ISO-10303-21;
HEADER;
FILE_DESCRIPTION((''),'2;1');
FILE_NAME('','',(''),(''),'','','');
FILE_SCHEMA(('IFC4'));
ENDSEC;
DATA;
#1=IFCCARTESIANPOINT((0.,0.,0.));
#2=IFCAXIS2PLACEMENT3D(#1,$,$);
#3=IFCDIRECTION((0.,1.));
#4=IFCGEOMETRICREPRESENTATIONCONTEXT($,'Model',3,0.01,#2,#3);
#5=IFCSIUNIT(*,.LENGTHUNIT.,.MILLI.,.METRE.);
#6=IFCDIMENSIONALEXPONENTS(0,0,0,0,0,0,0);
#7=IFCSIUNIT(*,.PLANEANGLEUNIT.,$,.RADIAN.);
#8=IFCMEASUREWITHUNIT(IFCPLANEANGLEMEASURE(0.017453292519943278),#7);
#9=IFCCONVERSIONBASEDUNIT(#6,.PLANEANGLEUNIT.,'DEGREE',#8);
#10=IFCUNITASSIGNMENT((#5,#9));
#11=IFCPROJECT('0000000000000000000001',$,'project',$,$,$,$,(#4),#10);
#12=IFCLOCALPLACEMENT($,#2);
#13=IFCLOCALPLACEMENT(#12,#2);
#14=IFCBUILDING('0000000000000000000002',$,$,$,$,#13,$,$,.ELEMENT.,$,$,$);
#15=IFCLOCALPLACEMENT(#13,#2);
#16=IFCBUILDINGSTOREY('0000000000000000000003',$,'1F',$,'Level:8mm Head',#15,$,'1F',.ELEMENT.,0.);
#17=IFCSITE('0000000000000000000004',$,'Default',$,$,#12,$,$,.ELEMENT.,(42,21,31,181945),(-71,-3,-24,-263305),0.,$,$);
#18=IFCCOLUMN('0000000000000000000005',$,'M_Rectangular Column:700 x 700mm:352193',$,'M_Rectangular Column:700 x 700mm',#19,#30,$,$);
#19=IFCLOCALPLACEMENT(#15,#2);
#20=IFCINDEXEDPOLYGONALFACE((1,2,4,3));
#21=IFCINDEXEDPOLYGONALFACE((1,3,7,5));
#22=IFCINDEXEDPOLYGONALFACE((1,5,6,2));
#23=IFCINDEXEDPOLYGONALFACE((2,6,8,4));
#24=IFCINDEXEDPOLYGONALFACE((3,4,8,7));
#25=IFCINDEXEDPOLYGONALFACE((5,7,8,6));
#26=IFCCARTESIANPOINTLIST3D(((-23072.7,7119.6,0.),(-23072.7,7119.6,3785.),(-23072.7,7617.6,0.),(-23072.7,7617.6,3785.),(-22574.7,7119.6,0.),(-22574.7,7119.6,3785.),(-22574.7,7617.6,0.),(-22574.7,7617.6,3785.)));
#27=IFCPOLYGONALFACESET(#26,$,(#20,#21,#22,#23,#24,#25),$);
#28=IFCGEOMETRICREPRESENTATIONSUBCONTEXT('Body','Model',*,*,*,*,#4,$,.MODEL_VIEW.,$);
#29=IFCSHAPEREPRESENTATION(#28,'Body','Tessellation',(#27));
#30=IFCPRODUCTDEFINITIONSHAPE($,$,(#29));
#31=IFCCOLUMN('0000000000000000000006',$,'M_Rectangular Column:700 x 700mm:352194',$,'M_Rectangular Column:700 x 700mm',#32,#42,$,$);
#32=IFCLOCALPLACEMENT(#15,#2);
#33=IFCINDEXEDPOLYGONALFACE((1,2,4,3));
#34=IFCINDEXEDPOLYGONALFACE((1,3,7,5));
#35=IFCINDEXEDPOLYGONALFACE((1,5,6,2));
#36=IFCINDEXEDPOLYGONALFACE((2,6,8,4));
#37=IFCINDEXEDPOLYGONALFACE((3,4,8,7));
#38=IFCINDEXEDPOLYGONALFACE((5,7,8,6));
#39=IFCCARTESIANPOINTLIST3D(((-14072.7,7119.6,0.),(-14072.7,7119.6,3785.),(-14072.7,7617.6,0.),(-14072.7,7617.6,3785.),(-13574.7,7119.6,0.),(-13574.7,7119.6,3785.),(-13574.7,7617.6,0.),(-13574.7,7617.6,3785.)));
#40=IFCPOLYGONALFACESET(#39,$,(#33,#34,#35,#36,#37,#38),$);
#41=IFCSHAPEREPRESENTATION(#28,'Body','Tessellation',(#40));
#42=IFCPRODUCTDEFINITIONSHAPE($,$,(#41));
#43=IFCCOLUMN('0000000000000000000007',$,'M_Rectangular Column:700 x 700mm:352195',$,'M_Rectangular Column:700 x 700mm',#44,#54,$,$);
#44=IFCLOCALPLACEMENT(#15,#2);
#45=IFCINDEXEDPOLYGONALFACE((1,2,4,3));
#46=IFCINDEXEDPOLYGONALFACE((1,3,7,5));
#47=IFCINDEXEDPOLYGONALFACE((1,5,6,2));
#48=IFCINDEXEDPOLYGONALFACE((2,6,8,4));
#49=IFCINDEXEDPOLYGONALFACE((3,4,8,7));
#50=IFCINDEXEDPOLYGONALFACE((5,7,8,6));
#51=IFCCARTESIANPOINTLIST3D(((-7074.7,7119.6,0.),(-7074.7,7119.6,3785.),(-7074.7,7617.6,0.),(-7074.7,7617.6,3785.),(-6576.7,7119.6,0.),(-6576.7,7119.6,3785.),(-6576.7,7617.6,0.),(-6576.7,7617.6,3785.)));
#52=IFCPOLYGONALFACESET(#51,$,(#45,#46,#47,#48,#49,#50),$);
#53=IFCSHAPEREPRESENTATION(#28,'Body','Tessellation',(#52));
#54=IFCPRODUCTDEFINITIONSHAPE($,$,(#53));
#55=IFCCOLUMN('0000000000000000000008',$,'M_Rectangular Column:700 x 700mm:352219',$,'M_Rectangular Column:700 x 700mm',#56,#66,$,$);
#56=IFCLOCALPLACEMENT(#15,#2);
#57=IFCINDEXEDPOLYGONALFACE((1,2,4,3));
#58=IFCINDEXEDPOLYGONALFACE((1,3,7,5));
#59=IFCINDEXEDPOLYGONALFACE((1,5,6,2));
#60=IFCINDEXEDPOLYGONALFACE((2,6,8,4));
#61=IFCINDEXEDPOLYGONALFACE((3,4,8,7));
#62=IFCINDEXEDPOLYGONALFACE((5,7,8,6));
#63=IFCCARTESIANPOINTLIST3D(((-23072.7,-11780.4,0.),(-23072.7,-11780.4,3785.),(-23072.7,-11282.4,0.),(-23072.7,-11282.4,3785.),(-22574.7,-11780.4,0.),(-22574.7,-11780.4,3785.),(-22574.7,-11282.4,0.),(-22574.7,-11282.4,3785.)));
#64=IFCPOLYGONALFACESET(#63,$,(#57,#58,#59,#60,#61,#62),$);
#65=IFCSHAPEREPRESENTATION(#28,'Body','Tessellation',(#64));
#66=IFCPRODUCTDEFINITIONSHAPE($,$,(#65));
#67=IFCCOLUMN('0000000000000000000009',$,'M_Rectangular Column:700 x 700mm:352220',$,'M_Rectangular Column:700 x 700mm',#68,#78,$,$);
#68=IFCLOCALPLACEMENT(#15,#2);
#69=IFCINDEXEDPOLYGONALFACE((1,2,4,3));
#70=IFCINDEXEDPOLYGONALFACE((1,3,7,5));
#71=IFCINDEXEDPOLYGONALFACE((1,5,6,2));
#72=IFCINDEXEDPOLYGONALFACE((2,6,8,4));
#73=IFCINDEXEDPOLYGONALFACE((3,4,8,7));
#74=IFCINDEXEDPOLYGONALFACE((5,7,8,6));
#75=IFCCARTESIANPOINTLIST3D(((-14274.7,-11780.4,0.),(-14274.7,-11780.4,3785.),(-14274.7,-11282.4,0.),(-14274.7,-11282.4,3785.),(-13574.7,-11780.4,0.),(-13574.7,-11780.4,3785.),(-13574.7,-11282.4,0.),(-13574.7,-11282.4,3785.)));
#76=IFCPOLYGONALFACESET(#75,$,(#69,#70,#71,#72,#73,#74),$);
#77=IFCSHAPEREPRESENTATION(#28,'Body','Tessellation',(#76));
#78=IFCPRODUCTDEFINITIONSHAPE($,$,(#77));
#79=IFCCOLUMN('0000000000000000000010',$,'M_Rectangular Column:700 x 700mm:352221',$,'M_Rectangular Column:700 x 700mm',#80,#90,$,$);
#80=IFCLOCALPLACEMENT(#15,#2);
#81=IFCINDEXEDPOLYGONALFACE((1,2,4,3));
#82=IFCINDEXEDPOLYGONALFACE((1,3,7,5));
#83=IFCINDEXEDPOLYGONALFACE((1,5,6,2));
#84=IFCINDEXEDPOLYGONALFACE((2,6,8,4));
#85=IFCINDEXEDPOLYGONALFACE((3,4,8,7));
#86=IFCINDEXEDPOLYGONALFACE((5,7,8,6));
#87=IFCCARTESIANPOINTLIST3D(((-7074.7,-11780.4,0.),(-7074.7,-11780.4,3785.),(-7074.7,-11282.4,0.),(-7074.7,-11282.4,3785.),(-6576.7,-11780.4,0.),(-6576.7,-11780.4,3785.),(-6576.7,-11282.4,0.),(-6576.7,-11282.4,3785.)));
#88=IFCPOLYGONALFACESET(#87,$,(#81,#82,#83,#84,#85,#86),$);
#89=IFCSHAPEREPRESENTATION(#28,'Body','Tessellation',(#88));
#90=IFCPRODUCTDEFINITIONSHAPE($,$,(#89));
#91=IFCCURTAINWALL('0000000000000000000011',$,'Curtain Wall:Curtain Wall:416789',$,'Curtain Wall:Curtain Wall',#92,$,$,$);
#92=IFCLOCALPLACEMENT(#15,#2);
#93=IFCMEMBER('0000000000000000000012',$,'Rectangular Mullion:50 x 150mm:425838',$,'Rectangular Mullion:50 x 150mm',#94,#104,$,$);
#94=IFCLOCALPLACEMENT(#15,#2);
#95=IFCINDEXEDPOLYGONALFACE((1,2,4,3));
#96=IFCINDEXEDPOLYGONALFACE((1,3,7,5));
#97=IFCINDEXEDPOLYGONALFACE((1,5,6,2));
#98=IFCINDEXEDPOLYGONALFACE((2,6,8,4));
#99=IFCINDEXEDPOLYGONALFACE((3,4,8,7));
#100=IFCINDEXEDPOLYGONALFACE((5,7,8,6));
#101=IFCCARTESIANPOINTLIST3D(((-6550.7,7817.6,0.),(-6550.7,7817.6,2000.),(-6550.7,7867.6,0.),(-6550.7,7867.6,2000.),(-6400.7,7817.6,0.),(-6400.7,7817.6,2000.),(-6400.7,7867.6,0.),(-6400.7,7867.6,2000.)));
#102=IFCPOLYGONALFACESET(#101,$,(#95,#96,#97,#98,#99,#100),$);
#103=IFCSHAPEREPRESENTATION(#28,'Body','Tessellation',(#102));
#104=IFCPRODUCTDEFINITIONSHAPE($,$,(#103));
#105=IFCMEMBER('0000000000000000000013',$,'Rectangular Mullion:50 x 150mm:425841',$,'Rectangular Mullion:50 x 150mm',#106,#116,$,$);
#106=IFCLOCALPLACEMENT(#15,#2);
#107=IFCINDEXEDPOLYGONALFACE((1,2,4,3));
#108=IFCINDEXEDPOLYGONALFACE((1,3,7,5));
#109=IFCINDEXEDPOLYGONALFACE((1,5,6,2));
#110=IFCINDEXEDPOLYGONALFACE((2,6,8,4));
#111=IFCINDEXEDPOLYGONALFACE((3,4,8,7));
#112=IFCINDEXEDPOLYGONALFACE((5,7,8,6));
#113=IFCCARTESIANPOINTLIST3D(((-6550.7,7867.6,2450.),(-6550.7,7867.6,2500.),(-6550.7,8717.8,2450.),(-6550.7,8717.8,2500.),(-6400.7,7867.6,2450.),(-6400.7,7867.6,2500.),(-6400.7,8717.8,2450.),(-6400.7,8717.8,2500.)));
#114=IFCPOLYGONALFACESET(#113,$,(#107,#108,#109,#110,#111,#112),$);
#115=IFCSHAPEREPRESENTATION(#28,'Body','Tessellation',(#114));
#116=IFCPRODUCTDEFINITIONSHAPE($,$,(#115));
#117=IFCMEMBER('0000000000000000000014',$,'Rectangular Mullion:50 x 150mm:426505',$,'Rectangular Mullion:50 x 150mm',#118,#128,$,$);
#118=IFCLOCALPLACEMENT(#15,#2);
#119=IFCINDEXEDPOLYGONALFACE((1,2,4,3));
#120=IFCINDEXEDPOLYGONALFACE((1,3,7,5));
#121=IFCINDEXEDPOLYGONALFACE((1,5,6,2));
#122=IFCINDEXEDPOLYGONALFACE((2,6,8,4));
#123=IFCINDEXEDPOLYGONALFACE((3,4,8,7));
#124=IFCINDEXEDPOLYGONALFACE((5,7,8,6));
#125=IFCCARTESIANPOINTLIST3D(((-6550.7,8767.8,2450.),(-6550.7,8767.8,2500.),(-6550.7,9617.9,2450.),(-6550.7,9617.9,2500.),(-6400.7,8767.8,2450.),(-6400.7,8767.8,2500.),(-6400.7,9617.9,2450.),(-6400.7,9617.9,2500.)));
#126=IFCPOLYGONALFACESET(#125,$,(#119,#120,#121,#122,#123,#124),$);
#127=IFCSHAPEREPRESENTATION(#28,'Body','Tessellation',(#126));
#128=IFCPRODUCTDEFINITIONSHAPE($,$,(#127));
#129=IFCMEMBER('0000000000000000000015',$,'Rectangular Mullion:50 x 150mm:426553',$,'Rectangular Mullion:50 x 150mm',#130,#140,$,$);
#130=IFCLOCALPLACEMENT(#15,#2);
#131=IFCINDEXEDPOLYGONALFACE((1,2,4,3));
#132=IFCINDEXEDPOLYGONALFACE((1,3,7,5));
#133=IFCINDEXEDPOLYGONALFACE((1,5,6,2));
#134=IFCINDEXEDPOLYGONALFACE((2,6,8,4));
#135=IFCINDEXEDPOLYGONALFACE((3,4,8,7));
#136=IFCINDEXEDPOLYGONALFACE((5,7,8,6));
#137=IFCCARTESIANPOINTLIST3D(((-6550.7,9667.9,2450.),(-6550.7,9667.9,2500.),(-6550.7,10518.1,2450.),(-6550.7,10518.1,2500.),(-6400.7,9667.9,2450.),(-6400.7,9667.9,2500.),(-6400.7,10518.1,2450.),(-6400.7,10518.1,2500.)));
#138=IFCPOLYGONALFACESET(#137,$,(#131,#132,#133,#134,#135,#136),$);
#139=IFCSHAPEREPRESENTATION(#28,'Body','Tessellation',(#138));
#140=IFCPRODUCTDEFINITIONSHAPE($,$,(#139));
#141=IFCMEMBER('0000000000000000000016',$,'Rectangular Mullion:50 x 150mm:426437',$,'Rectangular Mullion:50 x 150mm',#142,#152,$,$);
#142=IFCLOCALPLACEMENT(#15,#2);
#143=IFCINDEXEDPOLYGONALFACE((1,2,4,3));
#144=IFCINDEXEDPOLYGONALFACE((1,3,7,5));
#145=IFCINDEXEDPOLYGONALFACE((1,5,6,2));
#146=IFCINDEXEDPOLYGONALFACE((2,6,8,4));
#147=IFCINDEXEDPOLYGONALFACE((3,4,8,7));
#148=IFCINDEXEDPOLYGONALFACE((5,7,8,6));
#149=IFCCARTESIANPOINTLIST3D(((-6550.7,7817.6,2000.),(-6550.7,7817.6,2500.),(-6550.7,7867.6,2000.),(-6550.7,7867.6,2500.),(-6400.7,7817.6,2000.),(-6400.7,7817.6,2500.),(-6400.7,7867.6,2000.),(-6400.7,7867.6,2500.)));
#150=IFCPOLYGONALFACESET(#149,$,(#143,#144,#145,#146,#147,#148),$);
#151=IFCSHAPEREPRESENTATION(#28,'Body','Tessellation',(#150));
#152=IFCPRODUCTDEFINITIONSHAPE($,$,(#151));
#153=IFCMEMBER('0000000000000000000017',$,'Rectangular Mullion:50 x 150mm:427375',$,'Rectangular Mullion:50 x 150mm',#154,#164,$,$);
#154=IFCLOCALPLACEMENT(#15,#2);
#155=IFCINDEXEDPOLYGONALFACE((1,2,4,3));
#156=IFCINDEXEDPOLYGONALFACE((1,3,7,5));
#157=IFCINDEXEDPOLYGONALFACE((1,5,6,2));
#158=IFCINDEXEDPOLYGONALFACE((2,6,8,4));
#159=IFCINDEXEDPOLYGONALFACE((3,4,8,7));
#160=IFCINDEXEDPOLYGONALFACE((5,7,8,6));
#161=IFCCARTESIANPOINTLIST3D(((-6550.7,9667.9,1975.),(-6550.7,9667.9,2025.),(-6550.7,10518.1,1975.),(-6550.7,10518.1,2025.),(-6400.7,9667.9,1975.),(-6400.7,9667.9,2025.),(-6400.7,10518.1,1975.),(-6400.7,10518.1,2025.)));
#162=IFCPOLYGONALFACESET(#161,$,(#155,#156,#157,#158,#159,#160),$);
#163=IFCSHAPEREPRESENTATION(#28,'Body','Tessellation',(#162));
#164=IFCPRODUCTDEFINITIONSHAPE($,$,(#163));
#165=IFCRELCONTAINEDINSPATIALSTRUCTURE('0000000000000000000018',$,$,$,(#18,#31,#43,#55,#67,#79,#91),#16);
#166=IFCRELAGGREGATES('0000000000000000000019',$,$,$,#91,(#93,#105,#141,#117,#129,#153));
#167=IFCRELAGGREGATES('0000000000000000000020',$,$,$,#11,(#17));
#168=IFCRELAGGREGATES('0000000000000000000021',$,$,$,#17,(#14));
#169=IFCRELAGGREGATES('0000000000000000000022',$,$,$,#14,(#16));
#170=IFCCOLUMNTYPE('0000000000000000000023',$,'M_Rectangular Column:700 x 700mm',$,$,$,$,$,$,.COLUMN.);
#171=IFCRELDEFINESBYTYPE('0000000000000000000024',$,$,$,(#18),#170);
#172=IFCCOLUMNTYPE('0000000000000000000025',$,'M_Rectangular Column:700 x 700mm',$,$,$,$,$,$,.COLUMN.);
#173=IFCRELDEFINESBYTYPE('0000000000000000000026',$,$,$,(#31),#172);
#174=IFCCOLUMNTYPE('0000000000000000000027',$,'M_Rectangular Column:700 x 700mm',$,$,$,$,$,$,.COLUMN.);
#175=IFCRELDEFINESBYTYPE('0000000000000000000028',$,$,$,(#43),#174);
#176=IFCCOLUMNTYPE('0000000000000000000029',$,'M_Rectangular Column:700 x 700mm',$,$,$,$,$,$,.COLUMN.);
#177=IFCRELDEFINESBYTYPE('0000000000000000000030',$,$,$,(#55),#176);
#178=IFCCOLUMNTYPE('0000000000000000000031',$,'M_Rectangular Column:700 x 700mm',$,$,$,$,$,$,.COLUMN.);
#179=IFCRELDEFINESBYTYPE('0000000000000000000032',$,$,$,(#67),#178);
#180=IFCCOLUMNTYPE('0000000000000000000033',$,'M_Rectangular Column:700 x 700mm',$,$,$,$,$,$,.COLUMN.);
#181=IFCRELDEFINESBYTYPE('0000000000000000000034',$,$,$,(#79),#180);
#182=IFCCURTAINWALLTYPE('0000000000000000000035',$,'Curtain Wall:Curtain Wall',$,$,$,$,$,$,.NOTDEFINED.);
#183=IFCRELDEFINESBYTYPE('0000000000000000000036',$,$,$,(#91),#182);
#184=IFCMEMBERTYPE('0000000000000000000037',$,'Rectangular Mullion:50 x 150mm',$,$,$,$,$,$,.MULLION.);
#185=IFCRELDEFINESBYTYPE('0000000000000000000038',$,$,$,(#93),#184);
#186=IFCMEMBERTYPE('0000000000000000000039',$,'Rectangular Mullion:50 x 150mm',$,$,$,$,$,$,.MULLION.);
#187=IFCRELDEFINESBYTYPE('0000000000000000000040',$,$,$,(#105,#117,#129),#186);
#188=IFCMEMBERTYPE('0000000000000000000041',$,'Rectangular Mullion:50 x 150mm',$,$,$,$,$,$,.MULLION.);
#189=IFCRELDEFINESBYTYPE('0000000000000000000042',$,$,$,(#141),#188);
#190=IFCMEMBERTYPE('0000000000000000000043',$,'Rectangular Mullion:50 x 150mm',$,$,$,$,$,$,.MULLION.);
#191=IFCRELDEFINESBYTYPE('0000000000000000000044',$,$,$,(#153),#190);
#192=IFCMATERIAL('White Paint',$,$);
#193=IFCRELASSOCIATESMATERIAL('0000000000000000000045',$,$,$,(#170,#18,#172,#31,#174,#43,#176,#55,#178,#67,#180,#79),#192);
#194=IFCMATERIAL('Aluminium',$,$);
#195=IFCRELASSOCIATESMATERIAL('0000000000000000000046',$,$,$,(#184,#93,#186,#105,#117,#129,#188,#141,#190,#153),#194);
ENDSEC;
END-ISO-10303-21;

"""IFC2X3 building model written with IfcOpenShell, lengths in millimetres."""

from ifc_helpers import new_model, entity, si_unit, converted_unit, direction, frame, frame_2d, origin, origin_2d_with_axis, place, context, subcontext, project, spatial, rectangle, extrude, source, transform, mapped, material, type_object, type_shapes, element, aggregate, save


model = new_model("IFC2X3")

# Units and contexts
model_context = context("Model", 3, precision=0.01, world=origin(), true_north=direction((0.0, 1.0)))
body_context = subcontext(model_context, "Body", "Model", "MODEL_VIEW")
ifc_project = project(units=[si_unit("LENGTHUNIT", "METRE", prefix="MILLI"), converted_unit("PLANEANGLEUNIT", "DEGREE", entity("IfcPlaneAngleMeasure", 0.017453292519943278), si_unit("PLANEANGLEUNIT", "RADIAN"), dimensions=[0, 0, 0, 0, 0, 0, 0])], contexts=[model_context])

# Site, building, storey
site_placement = place(None, origin())
site = spatial("IfcSite", under=ifc_project, at=site_placement, Name="Default", CompositionType="ELEMENT", RefLatitude=(42, 21, 31, 181945), RefLongitude=(-71, -3, -24, -263305), RefElevation=0.0)
building_placement = place(site_placement, origin())
building = spatial("IfcBuilding", under=site, at=building_placement, CompositionType="ELEMENT")
storey_placement = place(building_placement, origin())
storey = spatial("IfcBuildingStorey", under=building, at=storey_placement, Name="1F", ObjectType="Level:8mm Head", LongName="1F", CompositionType="ELEMENT", Elevation=0.0)

# Columns
ifc_material_1 = material(Name="White Paint")
column_type_1 = type_object("IfcColumnType", Name="M_Rectangular Column:700 x 700mm", PredefinedType="COLUMN", material=ifc_material_1)
shared_shape_1 = source(origin(), body_context, "Body", "SweptSolid", [
    extrude(rectangle(XDim=498.0, YDim=498.0, at=frame_2d((0.0, 0.0), x_axis=(1.0, 0.0))), frame((-22823.7, 7368.6, 0.0), z_axis=(0.0, 0.0, 1.0), x_axis=(0.0, -1.0, 0.0)), (0.0, 0.0, 1.0), 3785.0),
])
type_shapes(column_type_1, [shared_shape_1])
column_1_placement = place(storey_placement, origin())
element("IfcColumn", 1, at=column_1_placement, inside=storey, type_object=column_type_1, material=ifc_material_1, Name="M_Rectangular Column:700 x 700mm:352193", ObjectType="M_Rectangular Column:700 x 700mm", context=body_context, shape_type="MappedRepresentation", body=[
    mapped(shared_shape_1, transform((0.0, 0.0, 0.0), scale=1.0)),
])
column_type_2 = type_object("IfcColumnType", Name="M_Rectangular Column:700 x 700mm", PredefinedType="COLUMN", material=ifc_material_1)
shared_shape_2 = source(origin(), body_context, "Body", "SweptSolid", [
    extrude(rectangle(XDim=498.0, YDim=498.0, at=frame_2d((0.0, 0.0), x_axis=(1.0, 0.0))), frame((-13823.7, 7368.6, 0.0), z_axis=(0.0, 0.0, 1.0), x_axis=(-1.0, 0.0, 0.0)), (0.0, 0.0, 1.0), 3785.0),
])
type_shapes(column_type_2, [shared_shape_2])
column_2_placement = place(storey_placement, origin())
element("IfcColumn", 2, at=column_2_placement, inside=storey, type_object=column_type_2, material=ifc_material_1, Name="M_Rectangular Column:700 x 700mm:352194", ObjectType="M_Rectangular Column:700 x 700mm", context=body_context, shape_type="MappedRepresentation", body=[
    mapped(shared_shape_2, transform((0.0, 0.0, 0.0), scale=1.0)),
])
column_type_3 = type_object("IfcColumnType", Name="M_Rectangular Column:700 x 700mm", PredefinedType="COLUMN", material=ifc_material_1)
shared_shape_3 = source(origin(), body_context, "Body", "SweptSolid", [
    extrude(rectangle(XDim=498.0, YDim=498.0, at=frame_2d((0.0, 0.0), x_axis=(1.0, 0.0))), frame((-6825.7, 7368.6, 0.0)), (0.0, 0.0, 1.0), 3785.0),
])
type_shapes(column_type_3, [shared_shape_3])
column_3_placement = place(storey_placement, origin())
element("IfcColumn", 3, at=column_3_placement, inside=storey, type_object=column_type_3, material=ifc_material_1, Name="M_Rectangular Column:700 x 700mm:352195", ObjectType="M_Rectangular Column:700 x 700mm", context=body_context, shape_type="MappedRepresentation", body=[
    mapped(shared_shape_3, transform((0.0, 0.0, 0.0), scale=1.0)),
])
column_type_4 = type_object("IfcColumnType", Name="M_Rectangular Column:700 x 700mm", PredefinedType="COLUMN", material=ifc_material_1)
shared_shape_4 = source(origin(), body_context, "Body", "SweptSolid", [
    extrude(rectangle(XDim=498.0, YDim=498.0, at=frame_2d((0.0, 0.0), x_axis=(1.0, 0.0))), frame((-22823.7, -11531.4, 0.0), z_axis=(0.0, 0.0, 1.0), x_axis=(0.0, -1.0, 0.0)), (0.0, 0.0, 1.0), 3785.0),
])
type_shapes(column_type_4, [shared_shape_4])
column_4_placement = place(storey_placement, origin())
element("IfcColumn", 4, at=column_4_placement, inside=storey, type_object=column_type_4, material=ifc_material_1, Name="M_Rectangular Column:700 x 700mm:352219", ObjectType="M_Rectangular Column:700 x 700mm", context=body_context, shape_type="MappedRepresentation", body=[
    mapped(shared_shape_4, transform((0.0, 0.0, 0.0), scale=1.0)),
])
column_type_5 = type_object("IfcColumnType", Name="M_Rectangular Column:700 x 700mm", PredefinedType="COLUMN", material=ifc_material_1)
shared_shape_5 = source(origin(), body_context, "Body", "SweptSolid", [
    extrude(rectangle(XDim=3785.0, YDim=498.0, at=frame_2d((0.0, 0.0), x_axis=(1.0, 0.0))), frame((-14274.7, -11531.4, 1892.5), z_axis=(1.0, 0.0, 0.0), x_axis=(0.0, 0.0, 1.0)), (0.0, 0.0, 1.0), 700.0),
])
type_shapes(column_type_5, [shared_shape_5])
column_5_placement = place(storey_placement, origin())
element("IfcColumn", 5, at=column_5_placement, inside=storey, type_object=column_type_5, material=ifc_material_1, Name="M_Rectangular Column:700 x 700mm:352220", ObjectType="M_Rectangular Column:700 x 700mm", context=body_context, shape_type="MappedRepresentation", body=[
    mapped(shared_shape_5, transform((0.0, 0.0, 0.0), scale=1.0)),
])
column_type_6 = type_object("IfcColumnType", Name="M_Rectangular Column:700 x 700mm", PredefinedType="COLUMN", material=ifc_material_1)
shared_shape_6 = source(origin(), body_context, "Body", "SweptSolid", [
    extrude(rectangle(XDim=498.0, YDim=498.0, at=frame_2d((0.0, 0.0), x_axis=(1.0, 0.0))), frame((-6825.7, -11531.4, 0.0)), (0.0, 0.0, 1.0), 3785.0),
])
type_shapes(column_type_6, [shared_shape_6])
column_6_placement = place(storey_placement, origin())
element("IfcColumn", 6, at=column_6_placement, inside=storey, type_object=column_type_6, material=ifc_material_1, Name="M_Rectangular Column:700 x 700mm:352221", ObjectType="M_Rectangular Column:700 x 700mm", context=body_context, shape_type="MappedRepresentation", body=[
    mapped(shared_shape_6, transform((0.0, 0.0, 0.0), scale=1.0)),
])

# Curtain wall, members
curtain_wall_type = type_object("IfcCurtainWallType", Name="Curtain Wall:Curtain Wall", PredefinedType="NOTDEFINED")
curtain_wall_placement = place(storey_placement, origin())
curtain_wall = element("IfcCurtainWall", 7, at=curtain_wall_placement, inside=storey, type_object=curtain_wall_type, Name="Curtain Wall:Curtain Wall:416789", ObjectType="Curtain Wall:Curtain Wall")
ifc_material_2 = material(Name="Aluminium")
member_type_1 = type_object("IfcMemberType", Name="Rectangular Mullion:50 x 150mm", PredefinedType="MULLION", material=ifc_material_2)
shared_shape_7 = source(origin(), body_context, "Body", "SweptSolid", [
    extrude(rectangle(XDim=50.0, YDim=150.0, at=origin_2d_with_axis()), frame((-25.0, 0.0, -2000.0), z_axis=(0.0, 0.0, 1.0), x_axis=(-1.0, 0.0, 0.0)), (0.0, 0.0, 1.0), 2000.0),
])
type_shapes(member_type_1, [shared_shape_7])
member_1_placement = place(curtain_wall_placement, frame((-6475.7, 7817.6, 0.0), z_axis=(0.0, 0.0, -1.0), x_axis=(0.0, -1.0, 0.0)))
member_1 = element("IfcMember", 8, at=member_1_placement, type_object=member_type_1, material=ifc_material_2, Name="Rectangular Mullion:50 x 150mm:425838", ObjectType="Rectangular Mullion:50 x 150mm", context=body_context, shape_type="MappedRepresentation", body=[
    mapped(shared_shape_7, transform((0.0, 0.0, 0.0), scale=1.0)),
])
member_type_2 = type_object("IfcMemberType", Name="Rectangular Mullion:50 x 150mm", PredefinedType="MULLION", material=ifc_material_2)
shared_shape_8 = source(origin(), body_context, "Body", "SweptSolid", [
    extrude(rectangle(XDim=50.0, YDim=150.0, at=origin_2d_with_axis()), frame((-25.0, 0.0, -850.2), z_axis=(0.0, 0.0, 1.0), x_axis=(-1.0, 0.0, 0.0)), (0.0, 0.0, 1.0), 850.2),
])
type_shapes(member_type_2, [shared_shape_8])
member_2_placement = place(curtain_wall_placement, frame((-6475.7, 7867.6, 2500.0), z_axis=(0.0, -1.0, 0.0), x_axis=(0.0, 0.0, 1.0)))
member_2 = element("IfcMember", 9, at=member_2_placement, type_object=member_type_2, material=ifc_material_2, Name="Rectangular Mullion:50 x 150mm:425841", ObjectType="Rectangular Mullion:50 x 150mm", context=body_context, shape_type="MappedRepresentation", body=[
    mapped(shared_shape_8, transform((0.0, 0.0, 0.0), scale=1.0)),
])
member_3_placement = place(curtain_wall_placement, frame((-6475.7, 8767.8, 2500.0), z_axis=(0.0, -1.0, 0.0), x_axis=(0.0, 0.0, 1.0)))
member_3 = element("IfcMember", 10, at=member_3_placement, type_object=member_type_2, material=ifc_material_2, Name="Rectangular Mullion:50 x 150mm:426505", ObjectType="Rectangular Mullion:50 x 150mm", context=body_context, shape_type="MappedRepresentation", body=[
    mapped(shared_shape_8, transform((0.0, 0.0, 0.0), scale=1.0)),
])
member_4_placement = place(curtain_wall_placement, frame((-6475.7, 9667.9, 2500.0), z_axis=(0.0, -1.0, 0.0), x_axis=(0.0, 0.0, 1.0)))
member_4 = element("IfcMember", 11, at=member_4_placement, type_object=member_type_2, material=ifc_material_2, Name="Rectangular Mullion:50 x 150mm:426553", ObjectType="Rectangular Mullion:50 x 150mm", context=body_context, shape_type="MappedRepresentation", body=[
    mapped(shared_shape_8, transform((0.0, 0.0, 0.0), scale=1.0)),
])
member_type_3 = type_object("IfcMemberType", Name="Rectangular Mullion:50 x 150mm", PredefinedType="MULLION", material=ifc_material_2)
shared_shape_9 = source(origin(), body_context, "Body", "SweptSolid", [
    extrude(rectangle(XDim=50.0, YDim=150.0, at=origin_2d_with_axis()), frame((-25.0, 0.0, -500.0), z_axis=(0.0, 0.0, 1.0), x_axis=(-1.0, 0.0, 0.0)), (0.0, 0.0, 1.0), 500.0),
])
type_shapes(member_type_3, [shared_shape_9])
member_5_placement = place(curtain_wall_placement, frame((-6475.7, 7817.6, 2000.0), z_axis=(0.0, 0.0, -1.0), x_axis=(0.0, -1.0, 0.0)))
member_5 = element("IfcMember", 12, at=member_5_placement, type_object=member_type_3, material=ifc_material_2, Name="Rectangular Mullion:50 x 150mm:426437", ObjectType="Rectangular Mullion:50 x 150mm", context=body_context, shape_type="MappedRepresentation", body=[
    mapped(shared_shape_9, transform((0.0, 0.0, 0.0), scale=1.0)),
])
member_type_4 = type_object("IfcMemberType", Name="Rectangular Mullion:50 x 150mm", PredefinedType="MULLION", material=ifc_material_2)
shared_shape_10 = source(origin(), body_context, "Body", "SweptSolid", [
    extrude(rectangle(XDim=50.0, YDim=150.0, at=origin_2d_with_axis()), frame((0.0, 0.0, -850.2), z_axis=(0.0, 0.0, 1.0), x_axis=(-1.0, 0.0, 0.0)), (0.0, 0.0, 1.0), 850.2),
])
type_shapes(member_type_4, [shared_shape_10])
member_6_placement = place(curtain_wall_placement, frame((-6475.7, 9667.9, 2000.0), z_axis=(0.0, -1.0, 0.0), x_axis=(0.0, 0.0, 1.0)))
member_6 = element("IfcMember", 13, at=member_6_placement, type_object=member_type_4, material=ifc_material_2, Name="Rectangular Mullion:50 x 150mm:427375", ObjectType="Rectangular Mullion:50 x 150mm", context=body_context, shape_type="MappedRepresentation", body=[
    mapped(shared_shape_10, transform((0.0, 0.0, 0.0), scale=1.0)),
])
aggregate(curtain_wall, [member_1, member_2, member_5, member_3, member_4, member_6])

save(model, "model.ifc")
